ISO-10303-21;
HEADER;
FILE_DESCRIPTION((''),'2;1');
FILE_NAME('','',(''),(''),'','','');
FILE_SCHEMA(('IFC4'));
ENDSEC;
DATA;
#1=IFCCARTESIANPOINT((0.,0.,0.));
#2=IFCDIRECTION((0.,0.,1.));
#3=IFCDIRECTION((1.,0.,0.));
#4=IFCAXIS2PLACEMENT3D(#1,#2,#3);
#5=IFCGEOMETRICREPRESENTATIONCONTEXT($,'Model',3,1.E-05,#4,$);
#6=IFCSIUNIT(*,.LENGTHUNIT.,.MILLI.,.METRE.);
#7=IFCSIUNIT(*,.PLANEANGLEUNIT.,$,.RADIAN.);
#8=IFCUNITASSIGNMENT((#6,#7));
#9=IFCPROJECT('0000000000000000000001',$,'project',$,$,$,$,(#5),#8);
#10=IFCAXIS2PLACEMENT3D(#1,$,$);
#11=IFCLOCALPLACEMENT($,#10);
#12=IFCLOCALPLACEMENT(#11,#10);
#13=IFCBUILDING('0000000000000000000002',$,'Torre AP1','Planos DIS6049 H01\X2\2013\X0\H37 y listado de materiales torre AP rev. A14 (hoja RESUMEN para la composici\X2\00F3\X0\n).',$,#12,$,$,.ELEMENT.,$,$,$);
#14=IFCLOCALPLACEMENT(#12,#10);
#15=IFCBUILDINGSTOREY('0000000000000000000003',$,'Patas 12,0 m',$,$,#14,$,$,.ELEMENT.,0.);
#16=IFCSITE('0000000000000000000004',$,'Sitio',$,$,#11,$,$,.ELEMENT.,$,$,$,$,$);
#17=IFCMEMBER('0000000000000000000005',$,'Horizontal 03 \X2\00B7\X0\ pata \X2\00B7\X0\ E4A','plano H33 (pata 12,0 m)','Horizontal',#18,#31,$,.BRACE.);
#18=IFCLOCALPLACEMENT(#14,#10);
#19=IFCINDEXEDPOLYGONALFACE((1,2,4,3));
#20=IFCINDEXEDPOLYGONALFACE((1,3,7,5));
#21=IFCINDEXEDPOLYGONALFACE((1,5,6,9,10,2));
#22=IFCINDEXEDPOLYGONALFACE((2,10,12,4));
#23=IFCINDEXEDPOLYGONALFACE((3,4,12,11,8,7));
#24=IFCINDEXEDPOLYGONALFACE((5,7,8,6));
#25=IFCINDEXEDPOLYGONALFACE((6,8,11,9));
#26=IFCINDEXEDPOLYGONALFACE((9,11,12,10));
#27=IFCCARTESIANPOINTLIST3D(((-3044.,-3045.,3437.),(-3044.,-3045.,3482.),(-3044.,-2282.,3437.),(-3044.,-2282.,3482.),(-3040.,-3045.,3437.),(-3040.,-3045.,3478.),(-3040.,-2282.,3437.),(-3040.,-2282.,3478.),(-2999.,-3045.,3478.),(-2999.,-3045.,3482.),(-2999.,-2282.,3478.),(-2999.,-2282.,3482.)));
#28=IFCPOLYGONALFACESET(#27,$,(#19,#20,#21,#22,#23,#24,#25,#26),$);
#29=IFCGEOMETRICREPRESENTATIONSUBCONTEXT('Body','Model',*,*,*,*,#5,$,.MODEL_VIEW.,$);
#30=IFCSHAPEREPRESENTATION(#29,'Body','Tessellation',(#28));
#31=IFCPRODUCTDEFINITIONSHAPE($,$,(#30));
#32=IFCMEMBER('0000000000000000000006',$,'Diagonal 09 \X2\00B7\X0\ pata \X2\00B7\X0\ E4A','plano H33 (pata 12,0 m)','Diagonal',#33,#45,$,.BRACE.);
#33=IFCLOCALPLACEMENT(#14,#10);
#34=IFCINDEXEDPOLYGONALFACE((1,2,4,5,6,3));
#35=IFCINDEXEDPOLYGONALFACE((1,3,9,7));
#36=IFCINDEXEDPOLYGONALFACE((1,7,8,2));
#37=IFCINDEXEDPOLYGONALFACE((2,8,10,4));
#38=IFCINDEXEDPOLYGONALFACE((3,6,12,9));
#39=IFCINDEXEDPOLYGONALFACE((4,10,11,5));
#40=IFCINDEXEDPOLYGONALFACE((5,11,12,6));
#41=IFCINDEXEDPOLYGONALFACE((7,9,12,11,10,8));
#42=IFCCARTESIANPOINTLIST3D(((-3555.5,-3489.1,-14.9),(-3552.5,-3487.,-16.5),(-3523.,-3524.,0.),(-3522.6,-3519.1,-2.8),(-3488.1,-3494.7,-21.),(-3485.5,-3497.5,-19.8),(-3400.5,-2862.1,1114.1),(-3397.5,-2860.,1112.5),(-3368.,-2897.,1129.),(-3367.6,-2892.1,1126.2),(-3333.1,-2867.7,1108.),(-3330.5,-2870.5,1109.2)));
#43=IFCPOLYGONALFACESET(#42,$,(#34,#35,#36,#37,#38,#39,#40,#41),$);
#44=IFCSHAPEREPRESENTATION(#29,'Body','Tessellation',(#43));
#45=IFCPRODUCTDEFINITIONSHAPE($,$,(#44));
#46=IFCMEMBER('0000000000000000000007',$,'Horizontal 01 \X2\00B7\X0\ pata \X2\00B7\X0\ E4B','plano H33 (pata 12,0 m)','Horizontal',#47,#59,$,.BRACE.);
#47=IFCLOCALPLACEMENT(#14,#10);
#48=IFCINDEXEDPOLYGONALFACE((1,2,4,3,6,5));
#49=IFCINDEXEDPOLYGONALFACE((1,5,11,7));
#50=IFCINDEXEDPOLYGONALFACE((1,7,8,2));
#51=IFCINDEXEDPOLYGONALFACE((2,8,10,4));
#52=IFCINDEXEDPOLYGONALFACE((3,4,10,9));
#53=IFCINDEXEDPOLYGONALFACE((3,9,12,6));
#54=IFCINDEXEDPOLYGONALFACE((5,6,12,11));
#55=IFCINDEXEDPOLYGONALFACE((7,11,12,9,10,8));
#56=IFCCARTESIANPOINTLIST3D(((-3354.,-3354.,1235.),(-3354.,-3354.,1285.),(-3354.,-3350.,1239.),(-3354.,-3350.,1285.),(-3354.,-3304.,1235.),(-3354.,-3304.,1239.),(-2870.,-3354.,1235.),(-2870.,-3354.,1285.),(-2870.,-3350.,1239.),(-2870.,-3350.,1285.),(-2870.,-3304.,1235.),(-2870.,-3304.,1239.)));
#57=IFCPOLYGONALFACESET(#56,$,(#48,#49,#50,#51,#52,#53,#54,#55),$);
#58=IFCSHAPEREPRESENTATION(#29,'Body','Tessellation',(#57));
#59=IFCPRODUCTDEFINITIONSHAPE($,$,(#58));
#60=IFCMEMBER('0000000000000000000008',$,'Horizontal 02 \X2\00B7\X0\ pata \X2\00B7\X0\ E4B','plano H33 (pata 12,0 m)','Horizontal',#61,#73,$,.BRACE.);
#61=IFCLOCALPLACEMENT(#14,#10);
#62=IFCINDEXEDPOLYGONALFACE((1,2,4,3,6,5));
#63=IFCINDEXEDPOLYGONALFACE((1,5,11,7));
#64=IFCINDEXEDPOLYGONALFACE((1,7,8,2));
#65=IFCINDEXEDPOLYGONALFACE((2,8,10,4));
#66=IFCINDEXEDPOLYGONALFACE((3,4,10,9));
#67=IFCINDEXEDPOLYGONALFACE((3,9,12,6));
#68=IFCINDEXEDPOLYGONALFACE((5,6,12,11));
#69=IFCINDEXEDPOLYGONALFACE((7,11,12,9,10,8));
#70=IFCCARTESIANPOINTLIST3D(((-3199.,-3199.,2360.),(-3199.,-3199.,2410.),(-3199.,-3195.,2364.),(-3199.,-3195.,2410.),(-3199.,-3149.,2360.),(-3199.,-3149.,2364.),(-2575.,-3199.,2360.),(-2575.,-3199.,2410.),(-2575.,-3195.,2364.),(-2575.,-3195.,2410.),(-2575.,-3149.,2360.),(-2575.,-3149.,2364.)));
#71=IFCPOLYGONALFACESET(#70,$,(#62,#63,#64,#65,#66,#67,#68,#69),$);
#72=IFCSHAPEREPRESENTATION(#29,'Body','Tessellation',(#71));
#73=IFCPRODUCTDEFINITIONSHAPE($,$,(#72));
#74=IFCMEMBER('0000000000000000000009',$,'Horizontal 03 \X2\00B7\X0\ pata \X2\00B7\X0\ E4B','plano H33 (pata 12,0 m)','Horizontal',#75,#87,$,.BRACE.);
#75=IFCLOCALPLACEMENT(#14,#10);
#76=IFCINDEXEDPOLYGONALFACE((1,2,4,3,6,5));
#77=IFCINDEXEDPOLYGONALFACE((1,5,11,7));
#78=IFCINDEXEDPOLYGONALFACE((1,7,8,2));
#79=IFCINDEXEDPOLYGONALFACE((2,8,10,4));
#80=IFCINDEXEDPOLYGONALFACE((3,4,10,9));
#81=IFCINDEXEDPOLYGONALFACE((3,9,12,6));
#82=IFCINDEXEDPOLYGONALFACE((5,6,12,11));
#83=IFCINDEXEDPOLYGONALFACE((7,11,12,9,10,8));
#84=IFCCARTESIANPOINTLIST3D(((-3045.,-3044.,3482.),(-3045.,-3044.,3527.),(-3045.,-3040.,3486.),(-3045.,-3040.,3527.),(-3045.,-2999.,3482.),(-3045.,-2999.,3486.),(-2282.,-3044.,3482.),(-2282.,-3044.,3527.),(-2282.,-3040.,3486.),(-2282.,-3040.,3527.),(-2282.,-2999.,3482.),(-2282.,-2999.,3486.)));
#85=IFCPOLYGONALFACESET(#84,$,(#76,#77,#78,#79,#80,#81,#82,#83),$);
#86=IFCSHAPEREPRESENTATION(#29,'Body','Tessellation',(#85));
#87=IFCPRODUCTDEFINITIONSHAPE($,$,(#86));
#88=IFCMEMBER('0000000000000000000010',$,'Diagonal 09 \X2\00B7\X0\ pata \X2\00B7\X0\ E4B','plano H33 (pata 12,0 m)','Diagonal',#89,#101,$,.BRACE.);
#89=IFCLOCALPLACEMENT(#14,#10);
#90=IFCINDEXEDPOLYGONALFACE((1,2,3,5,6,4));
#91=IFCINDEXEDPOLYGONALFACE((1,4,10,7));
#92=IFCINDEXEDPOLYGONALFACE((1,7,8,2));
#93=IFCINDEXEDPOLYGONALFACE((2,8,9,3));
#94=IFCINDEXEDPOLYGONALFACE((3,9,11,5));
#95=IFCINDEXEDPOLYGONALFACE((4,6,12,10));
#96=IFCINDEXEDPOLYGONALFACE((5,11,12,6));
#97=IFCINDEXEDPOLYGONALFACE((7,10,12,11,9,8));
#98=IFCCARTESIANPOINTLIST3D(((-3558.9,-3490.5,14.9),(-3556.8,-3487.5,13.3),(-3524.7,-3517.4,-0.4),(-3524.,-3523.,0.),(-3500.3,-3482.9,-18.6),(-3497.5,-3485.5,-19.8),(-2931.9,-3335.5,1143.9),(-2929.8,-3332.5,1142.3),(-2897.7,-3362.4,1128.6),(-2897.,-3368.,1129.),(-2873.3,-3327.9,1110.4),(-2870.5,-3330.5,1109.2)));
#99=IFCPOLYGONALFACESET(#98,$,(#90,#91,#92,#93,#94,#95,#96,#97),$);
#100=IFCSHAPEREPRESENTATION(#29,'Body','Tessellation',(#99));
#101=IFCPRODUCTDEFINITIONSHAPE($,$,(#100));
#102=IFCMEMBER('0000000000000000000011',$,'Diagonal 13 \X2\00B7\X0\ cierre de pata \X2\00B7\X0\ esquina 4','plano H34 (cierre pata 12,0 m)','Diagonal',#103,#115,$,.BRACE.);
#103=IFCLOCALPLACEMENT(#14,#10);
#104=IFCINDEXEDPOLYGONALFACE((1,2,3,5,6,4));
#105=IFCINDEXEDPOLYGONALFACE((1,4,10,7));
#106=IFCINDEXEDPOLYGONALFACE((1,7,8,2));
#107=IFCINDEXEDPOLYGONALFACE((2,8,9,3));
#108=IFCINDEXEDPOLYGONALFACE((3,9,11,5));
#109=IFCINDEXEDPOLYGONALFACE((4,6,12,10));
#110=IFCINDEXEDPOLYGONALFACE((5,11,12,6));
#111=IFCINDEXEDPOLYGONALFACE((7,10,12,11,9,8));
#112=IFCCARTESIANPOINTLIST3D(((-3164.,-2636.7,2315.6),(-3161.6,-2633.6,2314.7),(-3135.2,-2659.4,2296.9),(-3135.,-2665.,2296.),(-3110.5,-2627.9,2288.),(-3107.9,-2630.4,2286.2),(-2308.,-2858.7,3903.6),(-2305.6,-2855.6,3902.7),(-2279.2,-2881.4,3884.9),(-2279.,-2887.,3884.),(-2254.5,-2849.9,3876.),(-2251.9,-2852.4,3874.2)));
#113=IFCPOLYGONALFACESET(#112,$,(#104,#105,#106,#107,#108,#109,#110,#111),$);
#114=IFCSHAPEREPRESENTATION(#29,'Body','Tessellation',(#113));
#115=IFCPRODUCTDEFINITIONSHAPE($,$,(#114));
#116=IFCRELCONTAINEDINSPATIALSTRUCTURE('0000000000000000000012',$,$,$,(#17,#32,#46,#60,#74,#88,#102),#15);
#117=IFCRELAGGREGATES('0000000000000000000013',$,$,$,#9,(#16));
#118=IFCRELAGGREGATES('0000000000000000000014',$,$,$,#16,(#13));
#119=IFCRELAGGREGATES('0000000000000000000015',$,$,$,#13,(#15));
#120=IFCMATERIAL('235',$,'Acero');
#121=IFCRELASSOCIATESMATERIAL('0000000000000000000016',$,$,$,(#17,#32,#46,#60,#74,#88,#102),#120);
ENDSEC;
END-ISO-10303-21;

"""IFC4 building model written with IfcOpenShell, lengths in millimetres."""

from ifc_helpers import new_model, si_unit, frame, frame_2d, origin, origin_with_axes, place, context, subcontext, project, spatial, l_section, extrude, material, element, save


model = new_model("IFC4")

# Units and contexts
model_context = context("Model", 3, precision=1e-05, world=origin_with_axes())
body_context = subcontext(model_context, "Body", "Model", "MODEL_VIEW")
ifc_project = project(units=[si_unit("LENGTHUNIT", "METRE", prefix="MILLI"), si_unit("PLANEANGLEUNIT", "RADIAN")], contexts=[model_context])

# Site, building, storey
site_placement = place(None, origin())
site = spatial("IfcSite", under=ifc_project, at=site_placement, Name="Sitio", CompositionType="ELEMENT")
building_placement = place(site_placement, origin())
building = spatial("IfcBuilding", under=site, at=building_placement, Name="Torre AP1", Description="Planos DIS6049 H01–H37 y listado de materiales torre AP rev. A14 (hoja RESUMEN para la composición).", CompositionType="ELEMENT")
storey_placement = place(building_placement, origin())
storey = spatial("IfcBuildingStorey", under=building, at=storey_placement, Name="Patas 12,0 m", CompositionType="ELEMENT", Elevation=0.0)

# Members
ifc_material_1 = material(Name="235", Category="Acero")
member_1_placement = place(storey_placement, frame((-3044.0, -3045.0, 3482.0), z_axis=(0.0, 1.0, 0.0), x_axis=(1.0, 0.0, 0.0)))
element("IfcMember", 1, at=member_1_placement, inside=storey, material=ifc_material_1, Name="Horizontal 03 · pata · E4A", Description="plano H33 (pata 12,0 m)", ObjectType="Horizontal", PredefinedType="BRACE", context=body_context, shape_type="SweptSolid", body=[
    extrude(l_section(Depth=45.0, Width=45.0, Thickness=4.0, at=frame_2d((22.5, 22.5))), None, (0.0, 0.0, 1.0), 763.0),
])
member_2_placement = place(storey_placement, frame((-3523.0, -3524.0, 0.0), z_axis=(0.119168, 0.482052, 0.868001), x_axis=(0.749974, 0.529193, -0.396855)))
element("IfcMember", 2, at=member_2_placement, inside=storey, material=ifc_material_1, Name="Diagonal 09 · pata · E4A", Description="plano H33 (pata 12,0 m)", ObjectType="Diagonal", PredefinedType="BRACE", context=body_context, shape_type="SweptSolid", body=[
    extrude(l_section(Depth=50.0, Width=50.0, Thickness=4.0, at=frame_2d((25.0, 25.0))), None, (0.0, 0.0, 1.0), 1300.7),
])
member_3_placement = place(storey_placement, frame((-3354.0, -3354.0, 1235.0), z_axis=(1.0, 0.0, 0.0), x_axis=(0.0, 1.0, 0.0)))
element("IfcMember", 3, at=member_3_placement, inside=storey, material=ifc_material_1, Name="Horizontal 01 · pata · E4B", Description="plano H33 (pata 12,0 m)", ObjectType="Horizontal", PredefinedType="BRACE", context=body_context, shape_type="SweptSolid", body=[
    extrude(l_section(Depth=50.0, Width=50.0, Thickness=4.0, at=frame_2d((25.0, 25.0))), None, (0.0, 0.0, 1.0), 484.0),
])
member_4_placement = place(storey_placement, frame((-3199.0, -3199.0, 2360.0), z_axis=(1.0, 0.0, 0.0), x_axis=(0.0, 1.0, 0.0)))
element("IfcMember", 4, at=member_4_placement, inside=storey, material=ifc_material_1, Name="Horizontal 02 · pata · E4B", Description="plano H33 (pata 12,0 m)", ObjectType="Horizontal", PredefinedType="BRACE", context=body_context, shape_type="SweptSolid", body=[
    extrude(l_section(Depth=50.0, Width=50.0, Thickness=4.0, at=frame_2d((25.0, 25.0))), None, (0.0, 0.0, 1.0), 624.0),
])
member_5_placement = place(storey_placement, frame((-3045.0, -3044.0, 3482.0), z_axis=(1.0, 0.0, 0.0), x_axis=(0.0, 1.0, 0.0)))
element("IfcMember", 5, at=member_5_placement, inside=storey, material=ifc_material_1, Name="Horizontal 03 · pata · E4B", Description="plano H33 (pata 12,0 m)", ObjectType="Horizontal", PredefinedType="BRACE", context=body_context, shape_type="SweptSolid", body=[
    extrude(l_section(Depth=45.0, Width=45.0, Thickness=4.0, at=frame_2d((22.5, 22.5))), None, (0.0, 0.0, 1.0), 763.0),
])
member_6_placement = place(storey_placement, frame((-3524.0, -3523.0, 0.0), z_axis=(0.482052, 0.119168, 0.868001), x_axis=(0.529193, 0.749974, -0.396855)))
element("IfcMember", 6, at=member_6_placement, inside=storey, material=ifc_material_1, Name="Diagonal 09 · pata · E4B", Description="plano H33 (pata 12,0 m)", ObjectType="Diagonal", PredefinedType="BRACE", context=body_context, shape_type="SweptSolid", body=[
    extrude(l_section(Depth=50.0, Width=50.0, Thickness=4.0, at=frame_2d((25.0, 25.0))), None, (0.0, 0.0, 1.0), 1300.7),
])
member_7_placement = place(storey_placement, frame((-3135.0, -2665.0, 2296.0), z_axis=(0.470944, -0.122137, 0.873667), x_axis=(0.602297, 0.768133, -0.21728)))
element("IfcMember", 7, at=member_7_placement, inside=storey, material=ifc_material_1, Name="Diagonal 13 · cierre de pata · esquina 4", Description="plano H34 (cierre pata 12,0 m)", ObjectType="Diagonal", PredefinedType="BRACE", context=body_context, shape_type="SweptSolid", body=[
    extrude(l_section(Depth=45.0, Width=45.0, Thickness=4.0, at=frame_2d((22.5, 22.5))), None, (0.0, 0.0, 1.0), 1817.6),
])

save(model, "model.ifc")
